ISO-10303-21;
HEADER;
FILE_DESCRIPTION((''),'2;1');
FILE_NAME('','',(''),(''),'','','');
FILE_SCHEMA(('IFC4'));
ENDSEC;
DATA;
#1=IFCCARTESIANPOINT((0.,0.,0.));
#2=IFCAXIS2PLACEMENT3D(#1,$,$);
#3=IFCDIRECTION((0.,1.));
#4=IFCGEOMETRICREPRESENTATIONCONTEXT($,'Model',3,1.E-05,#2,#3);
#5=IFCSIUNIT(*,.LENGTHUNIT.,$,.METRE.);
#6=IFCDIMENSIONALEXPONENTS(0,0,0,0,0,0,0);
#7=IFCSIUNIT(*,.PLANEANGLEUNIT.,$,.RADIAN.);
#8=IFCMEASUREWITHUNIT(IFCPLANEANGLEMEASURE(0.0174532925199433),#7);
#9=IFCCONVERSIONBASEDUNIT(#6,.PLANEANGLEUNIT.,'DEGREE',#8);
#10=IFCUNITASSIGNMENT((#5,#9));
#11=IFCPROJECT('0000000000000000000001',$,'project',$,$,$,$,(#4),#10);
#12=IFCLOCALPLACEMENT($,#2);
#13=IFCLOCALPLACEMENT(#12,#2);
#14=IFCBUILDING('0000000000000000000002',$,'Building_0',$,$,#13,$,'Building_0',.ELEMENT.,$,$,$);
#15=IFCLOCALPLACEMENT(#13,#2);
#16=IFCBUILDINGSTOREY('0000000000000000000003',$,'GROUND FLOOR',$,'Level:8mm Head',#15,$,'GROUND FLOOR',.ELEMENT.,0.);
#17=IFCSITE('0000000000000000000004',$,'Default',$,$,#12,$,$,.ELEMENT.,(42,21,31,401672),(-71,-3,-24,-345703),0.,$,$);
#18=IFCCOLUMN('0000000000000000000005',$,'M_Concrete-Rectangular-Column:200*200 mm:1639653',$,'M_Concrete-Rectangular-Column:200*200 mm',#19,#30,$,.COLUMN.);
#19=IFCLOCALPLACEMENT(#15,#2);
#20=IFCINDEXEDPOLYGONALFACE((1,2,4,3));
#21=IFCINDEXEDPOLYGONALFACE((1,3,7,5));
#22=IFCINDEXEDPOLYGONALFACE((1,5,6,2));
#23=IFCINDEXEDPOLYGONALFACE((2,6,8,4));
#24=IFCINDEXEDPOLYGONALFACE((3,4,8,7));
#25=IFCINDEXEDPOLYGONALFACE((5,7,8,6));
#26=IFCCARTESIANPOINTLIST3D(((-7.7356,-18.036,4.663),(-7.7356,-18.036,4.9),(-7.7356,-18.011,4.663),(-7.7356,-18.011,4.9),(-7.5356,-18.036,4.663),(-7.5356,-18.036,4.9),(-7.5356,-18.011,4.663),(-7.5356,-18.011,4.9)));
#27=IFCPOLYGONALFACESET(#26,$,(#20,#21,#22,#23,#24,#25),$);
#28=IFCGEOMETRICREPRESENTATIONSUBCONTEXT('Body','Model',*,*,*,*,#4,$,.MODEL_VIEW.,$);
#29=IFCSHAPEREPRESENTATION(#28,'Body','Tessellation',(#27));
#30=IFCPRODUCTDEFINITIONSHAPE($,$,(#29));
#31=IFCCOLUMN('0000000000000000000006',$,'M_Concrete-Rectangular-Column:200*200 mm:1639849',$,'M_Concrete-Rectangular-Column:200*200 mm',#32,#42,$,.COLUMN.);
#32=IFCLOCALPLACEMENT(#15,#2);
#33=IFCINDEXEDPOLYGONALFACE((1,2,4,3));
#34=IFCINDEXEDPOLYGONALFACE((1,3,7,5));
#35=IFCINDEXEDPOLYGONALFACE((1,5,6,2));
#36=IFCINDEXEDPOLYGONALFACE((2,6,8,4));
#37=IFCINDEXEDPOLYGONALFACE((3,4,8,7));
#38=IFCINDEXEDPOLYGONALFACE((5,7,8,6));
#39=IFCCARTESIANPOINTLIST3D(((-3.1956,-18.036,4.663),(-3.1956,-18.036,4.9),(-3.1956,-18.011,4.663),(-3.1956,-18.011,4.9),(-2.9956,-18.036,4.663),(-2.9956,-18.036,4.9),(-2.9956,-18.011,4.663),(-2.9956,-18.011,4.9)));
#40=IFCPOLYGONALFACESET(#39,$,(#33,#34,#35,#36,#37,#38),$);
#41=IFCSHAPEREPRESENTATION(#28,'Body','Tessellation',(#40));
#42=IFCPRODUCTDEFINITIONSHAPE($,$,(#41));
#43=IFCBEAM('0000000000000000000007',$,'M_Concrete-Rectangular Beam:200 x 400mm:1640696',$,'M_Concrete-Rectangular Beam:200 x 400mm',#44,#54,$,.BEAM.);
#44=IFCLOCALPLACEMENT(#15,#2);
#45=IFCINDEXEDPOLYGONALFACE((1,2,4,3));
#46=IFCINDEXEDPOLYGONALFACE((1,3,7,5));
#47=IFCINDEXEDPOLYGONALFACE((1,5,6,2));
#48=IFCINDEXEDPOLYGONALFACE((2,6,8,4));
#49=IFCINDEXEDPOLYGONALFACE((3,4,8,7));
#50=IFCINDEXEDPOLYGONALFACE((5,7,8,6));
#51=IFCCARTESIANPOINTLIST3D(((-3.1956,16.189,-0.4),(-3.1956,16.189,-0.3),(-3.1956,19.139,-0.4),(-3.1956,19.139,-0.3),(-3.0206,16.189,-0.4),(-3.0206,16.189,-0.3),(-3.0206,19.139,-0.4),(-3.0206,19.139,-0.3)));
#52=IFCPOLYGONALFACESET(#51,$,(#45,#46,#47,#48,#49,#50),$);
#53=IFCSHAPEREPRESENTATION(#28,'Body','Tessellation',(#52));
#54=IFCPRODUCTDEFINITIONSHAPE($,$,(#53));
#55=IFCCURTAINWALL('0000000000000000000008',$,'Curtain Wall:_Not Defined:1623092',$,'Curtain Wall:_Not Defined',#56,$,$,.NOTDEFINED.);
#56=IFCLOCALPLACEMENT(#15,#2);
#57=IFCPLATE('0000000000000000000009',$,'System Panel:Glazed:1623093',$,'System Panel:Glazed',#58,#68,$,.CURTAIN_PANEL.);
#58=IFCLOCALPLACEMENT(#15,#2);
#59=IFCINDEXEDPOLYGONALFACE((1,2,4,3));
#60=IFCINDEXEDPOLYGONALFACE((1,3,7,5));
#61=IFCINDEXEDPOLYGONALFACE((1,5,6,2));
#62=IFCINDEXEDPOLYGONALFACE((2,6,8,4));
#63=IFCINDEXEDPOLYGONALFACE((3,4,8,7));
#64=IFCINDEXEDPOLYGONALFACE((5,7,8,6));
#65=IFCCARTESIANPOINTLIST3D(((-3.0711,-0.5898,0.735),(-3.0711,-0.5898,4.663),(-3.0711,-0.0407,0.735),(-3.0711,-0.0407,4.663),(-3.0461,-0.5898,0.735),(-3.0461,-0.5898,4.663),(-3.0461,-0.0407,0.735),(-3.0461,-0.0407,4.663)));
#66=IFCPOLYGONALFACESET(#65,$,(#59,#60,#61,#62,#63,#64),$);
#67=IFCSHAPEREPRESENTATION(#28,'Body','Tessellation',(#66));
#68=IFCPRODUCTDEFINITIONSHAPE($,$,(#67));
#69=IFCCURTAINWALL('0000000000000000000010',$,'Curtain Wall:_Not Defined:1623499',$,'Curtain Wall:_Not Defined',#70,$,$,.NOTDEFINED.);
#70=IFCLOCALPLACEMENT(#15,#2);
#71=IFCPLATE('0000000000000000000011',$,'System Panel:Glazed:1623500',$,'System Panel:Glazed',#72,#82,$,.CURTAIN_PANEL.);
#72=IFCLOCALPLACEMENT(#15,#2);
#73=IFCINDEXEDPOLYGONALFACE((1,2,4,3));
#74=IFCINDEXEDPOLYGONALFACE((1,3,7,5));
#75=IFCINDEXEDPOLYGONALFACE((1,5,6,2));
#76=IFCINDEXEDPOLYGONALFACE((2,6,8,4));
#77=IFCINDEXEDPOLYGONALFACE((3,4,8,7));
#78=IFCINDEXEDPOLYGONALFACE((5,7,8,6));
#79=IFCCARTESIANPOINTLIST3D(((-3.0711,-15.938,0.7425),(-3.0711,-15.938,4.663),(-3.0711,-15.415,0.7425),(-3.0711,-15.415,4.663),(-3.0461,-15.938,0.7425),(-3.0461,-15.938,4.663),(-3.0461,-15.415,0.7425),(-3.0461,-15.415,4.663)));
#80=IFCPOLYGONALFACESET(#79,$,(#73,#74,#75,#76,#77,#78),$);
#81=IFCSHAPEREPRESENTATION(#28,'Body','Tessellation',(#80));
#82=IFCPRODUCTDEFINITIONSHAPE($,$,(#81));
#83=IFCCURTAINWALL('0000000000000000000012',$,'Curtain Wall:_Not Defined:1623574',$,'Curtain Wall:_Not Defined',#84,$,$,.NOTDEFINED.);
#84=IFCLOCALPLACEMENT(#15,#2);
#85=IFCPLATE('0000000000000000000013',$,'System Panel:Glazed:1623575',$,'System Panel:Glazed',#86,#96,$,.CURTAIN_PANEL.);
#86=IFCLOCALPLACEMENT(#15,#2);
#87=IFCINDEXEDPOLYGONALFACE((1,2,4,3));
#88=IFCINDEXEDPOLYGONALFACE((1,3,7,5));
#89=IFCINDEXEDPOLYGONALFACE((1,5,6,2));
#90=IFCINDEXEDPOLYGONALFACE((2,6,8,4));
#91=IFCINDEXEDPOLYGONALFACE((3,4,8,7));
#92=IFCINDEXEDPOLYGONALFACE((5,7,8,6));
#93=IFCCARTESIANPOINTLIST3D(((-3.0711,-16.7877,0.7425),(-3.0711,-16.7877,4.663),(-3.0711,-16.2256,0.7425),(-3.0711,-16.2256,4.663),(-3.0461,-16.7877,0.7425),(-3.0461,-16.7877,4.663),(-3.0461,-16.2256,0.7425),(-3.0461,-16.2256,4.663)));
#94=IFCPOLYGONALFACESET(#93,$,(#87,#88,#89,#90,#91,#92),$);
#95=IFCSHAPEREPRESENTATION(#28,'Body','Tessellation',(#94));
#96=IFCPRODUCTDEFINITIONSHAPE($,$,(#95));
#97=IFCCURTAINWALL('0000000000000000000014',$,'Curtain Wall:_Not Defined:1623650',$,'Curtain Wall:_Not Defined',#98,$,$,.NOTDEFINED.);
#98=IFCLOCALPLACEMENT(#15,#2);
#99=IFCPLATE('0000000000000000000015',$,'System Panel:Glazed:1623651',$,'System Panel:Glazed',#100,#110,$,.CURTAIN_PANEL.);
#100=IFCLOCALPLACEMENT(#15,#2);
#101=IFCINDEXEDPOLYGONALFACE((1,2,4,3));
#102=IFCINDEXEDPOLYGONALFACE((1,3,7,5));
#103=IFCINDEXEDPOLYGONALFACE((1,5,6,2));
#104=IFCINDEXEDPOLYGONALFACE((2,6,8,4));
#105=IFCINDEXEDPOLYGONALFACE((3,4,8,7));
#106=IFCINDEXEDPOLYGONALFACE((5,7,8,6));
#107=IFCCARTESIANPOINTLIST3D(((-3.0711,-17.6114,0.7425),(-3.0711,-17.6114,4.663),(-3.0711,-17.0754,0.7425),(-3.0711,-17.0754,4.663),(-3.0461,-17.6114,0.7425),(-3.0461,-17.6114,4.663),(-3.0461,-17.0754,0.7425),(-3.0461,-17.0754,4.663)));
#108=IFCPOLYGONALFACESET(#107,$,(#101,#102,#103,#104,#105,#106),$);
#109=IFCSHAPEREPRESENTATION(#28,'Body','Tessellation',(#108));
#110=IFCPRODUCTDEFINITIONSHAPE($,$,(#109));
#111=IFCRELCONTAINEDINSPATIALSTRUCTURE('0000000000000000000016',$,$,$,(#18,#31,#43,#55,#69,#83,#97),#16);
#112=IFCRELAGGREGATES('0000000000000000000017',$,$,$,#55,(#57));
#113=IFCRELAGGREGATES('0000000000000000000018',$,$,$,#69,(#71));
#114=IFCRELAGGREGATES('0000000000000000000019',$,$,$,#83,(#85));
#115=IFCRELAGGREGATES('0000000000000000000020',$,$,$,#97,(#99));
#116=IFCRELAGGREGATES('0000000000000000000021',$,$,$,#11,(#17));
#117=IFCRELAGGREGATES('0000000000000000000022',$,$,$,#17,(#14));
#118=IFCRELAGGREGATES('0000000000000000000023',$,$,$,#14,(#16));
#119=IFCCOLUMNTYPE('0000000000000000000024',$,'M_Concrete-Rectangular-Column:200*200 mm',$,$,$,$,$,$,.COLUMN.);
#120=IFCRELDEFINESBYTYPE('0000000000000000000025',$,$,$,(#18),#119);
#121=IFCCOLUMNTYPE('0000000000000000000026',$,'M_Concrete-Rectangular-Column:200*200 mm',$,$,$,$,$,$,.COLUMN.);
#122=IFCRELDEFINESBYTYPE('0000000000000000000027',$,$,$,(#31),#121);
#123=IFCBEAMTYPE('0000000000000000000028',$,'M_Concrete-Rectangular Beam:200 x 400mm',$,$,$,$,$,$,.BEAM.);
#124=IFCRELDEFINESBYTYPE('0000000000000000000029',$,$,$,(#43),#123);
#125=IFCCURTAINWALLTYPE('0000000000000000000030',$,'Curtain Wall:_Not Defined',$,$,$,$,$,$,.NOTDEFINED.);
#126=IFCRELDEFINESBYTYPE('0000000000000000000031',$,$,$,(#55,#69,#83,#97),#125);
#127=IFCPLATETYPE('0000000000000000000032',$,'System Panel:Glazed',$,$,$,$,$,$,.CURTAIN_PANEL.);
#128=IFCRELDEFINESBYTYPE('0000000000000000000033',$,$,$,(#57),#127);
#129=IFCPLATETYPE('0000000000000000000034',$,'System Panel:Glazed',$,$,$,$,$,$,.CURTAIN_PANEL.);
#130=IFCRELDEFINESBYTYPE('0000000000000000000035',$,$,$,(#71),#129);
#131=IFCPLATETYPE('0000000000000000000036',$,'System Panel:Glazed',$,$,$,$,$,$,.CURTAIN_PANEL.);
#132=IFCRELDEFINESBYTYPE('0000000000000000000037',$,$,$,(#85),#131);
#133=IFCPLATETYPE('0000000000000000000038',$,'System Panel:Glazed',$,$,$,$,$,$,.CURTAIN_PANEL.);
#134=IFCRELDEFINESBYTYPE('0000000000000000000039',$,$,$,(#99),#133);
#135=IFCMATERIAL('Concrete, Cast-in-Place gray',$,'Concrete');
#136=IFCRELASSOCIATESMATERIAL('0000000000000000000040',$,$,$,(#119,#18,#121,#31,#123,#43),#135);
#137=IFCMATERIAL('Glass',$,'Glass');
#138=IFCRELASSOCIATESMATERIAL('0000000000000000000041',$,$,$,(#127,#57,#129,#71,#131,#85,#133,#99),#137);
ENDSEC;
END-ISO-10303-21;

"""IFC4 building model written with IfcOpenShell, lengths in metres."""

from ifc_helpers import new_model, entity, si_unit, converted_unit, direction, frame, origin, place, context, subcontext, project, spatial, indexed_curve, outline, extrude, source, transform, mapped, material, type_object, type_shapes, element, aggregate, save


model = new_model("IFC4")

# Units and contexts
model_context = context("Model", 3, precision=1e-05, world=origin(), true_north=direction((0.0, 1.0)))
body_context = subcontext(model_context, "Body", "Model", "MODEL_VIEW")
ifc_project = project(units=[si_unit("LENGTHUNIT", "METRE"), converted_unit("PLANEANGLEUNIT", "DEGREE", entity("IfcPlaneAngleMeasure", 0.0174532925199433), si_unit("PLANEANGLEUNIT", "RADIAN"), dimensions=[0, 0, 0, 0, 0, 0, 0])], contexts=[model_context])

# Site, building, storey
site_placement = place(None, origin())
site = spatial("IfcSite", under=ifc_project, at=site_placement, Name="Default", CompositionType="ELEMENT", RefLatitude=(42, 21, 31, 401672), RefLongitude=(-71, -3, -24, -345703), RefElevation=0.0)
building_placement = place(site_placement, origin())
building = spatial("IfcBuilding", under=site, at=building_placement, Name="Building_0", LongName="Building_0", CompositionType="ELEMENT")
storey_placement = place(building_placement, origin())
storey = spatial("IfcBuildingStorey", under=building, at=storey_placement, Name="GROUND FLOOR", ObjectType="Level:8mm Head", LongName="GROUND FLOOR", CompositionType="ELEMENT", Elevation=0.0)

# Columns
ifc_material_1 = material(Name="Concrete, Cast-in-Place gray", Category="Concrete")
column_type_1 = type_object("IfcColumnType", Name="M_Concrete-Rectangular-Column:200*200 mm", PredefinedType="COLUMN", material=ifc_material_1)
shared_shape_1 = source(origin(), body_context, "Body", "SweptSolid", [
    extrude(outline(indexed_curve([(-0.0125, -0.1185), (0.0125, -0.1185), (0.0125, 0.1185), (-0.0125, 0.1185), (-0.0125, -0.1185)], self_intersect=False)), frame((-7.7356, -18.0235, 4.7815), z_axis=(1.0, 0.0, 0.0), x_axis=(0.0, -1.0, 0.0)), (0.0, 0.0, 1.0), 0.2),
])
type_shapes(column_type_1, [shared_shape_1])
column_1_placement = place(storey_placement, origin())
element("IfcColumn", 1, at=column_1_placement, inside=storey, type_object=column_type_1, material=ifc_material_1, Name="M_Concrete-Rectangular-Column:200*200 mm:1639653", ObjectType="M_Concrete-Rectangular-Column:200*200 mm", PredefinedType="COLUMN", context=body_context, shape_type="MappedRepresentation", body=[
    mapped(shared_shape_1, transform((0.0, 0.0, 0.0), scale=1.0)),
])
column_type_2 = type_object("IfcColumnType", Name="M_Concrete-Rectangular-Column:200*200 mm", PredefinedType="COLUMN", material=ifc_material_1)
shared_shape_2 = source(origin(), body_context, "Body", "SweptSolid", [
    extrude(outline(indexed_curve([(-0.0125, -0.1185), (0.0125, -0.1185), (0.0125, 0.1185), (-0.0125, 0.1185), (-0.0125, -0.1185)], self_intersect=False)), frame((-3.1956, -18.0235, 4.7815), z_axis=(1.0, 0.0, 0.0), x_axis=(0.0, -1.0, 0.0)), (0.0, 0.0, 1.0), 0.2),
])
type_shapes(column_type_2, [shared_shape_2])
column_2_placement = place(storey_placement, origin())
element("IfcColumn", 2, at=column_2_placement, inside=storey, type_object=column_type_2, material=ifc_material_1, Name="M_Concrete-Rectangular-Column:200*200 mm:1639849", ObjectType="M_Concrete-Rectangular-Column:200*200 mm", PredefinedType="COLUMN", context=body_context, shape_type="MappedRepresentation", body=[
    mapped(shared_shape_2, transform((0.0, 0.0, 0.0), scale=1.0)),
])

# Beam
beam_type = type_object("IfcBeamType", Name="M_Concrete-Rectangular Beam:200 x 400mm", PredefinedType="BEAM", material=ifc_material_1)
shared_shape_3 = source(origin(), body_context, "Body", "SweptSolid", [
    extrude(outline(indexed_curve([(-0.0875, -0.05), (0.0875, -0.05), (0.0875, 0.05), (-0.0875, 0.05), (-0.0875, -0.05)], self_intersect=False)), frame((-3.1081, 19.139, -0.35), z_axis=(0.0, -1.0, 0.0), x_axis=(-1.0, 0.0, 0.0)), (0.0, 0.0, 1.0), 2.95),
])
type_shapes(beam_type, [shared_shape_3])
beam_placement = place(storey_placement, origin())
element("IfcBeam", 3, at=beam_placement, inside=storey, type_object=beam_type, material=ifc_material_1, Name="M_Concrete-Rectangular Beam:200 x 400mm:1640696", ObjectType="M_Concrete-Rectangular Beam:200 x 400mm", PredefinedType="BEAM", context=body_context, shape_type="MappedRepresentation", body=[
    mapped(shared_shape_3, transform((0.0, 0.0, 0.0), scale=1.0)),
])

# Curtain walls, plates
curtain_wall_type = type_object("IfcCurtainWallType", Name="Curtain Wall:_Not Defined", PredefinedType="NOTDEFINED")
curtain_wall_1_placement = place(storey_placement, origin())
curtain_wall_1 = element("IfcCurtainWall", 4, at=curtain_wall_1_placement, inside=storey, type_object=curtain_wall_type, Name="Curtain Wall:_Not Defined:1623092", ObjectType="Curtain Wall:_Not Defined", PredefinedType="NOTDEFINED")
ifc_material_2 = material(Name="Glass", Category="Glass")
plate_type_1 = type_object("IfcPlateType", Name="System Panel:Glazed", PredefinedType="CURTAIN_PANEL", material=ifc_material_2)
shared_shape_4 = source(origin(), body_context, "Body", "SweptSolid", [
    extrude(outline(indexed_curve([(-0.0125, -0.2745), (0.0125, -0.2745), (0.0125, 0.2745), (-0.0125, 0.2745), (-0.0125, -0.2745)], self_intersect=False)), frame((0.0, 0.037, 0.0), z_axis=(0.0, 0.0, 1.0), x_axis=(0.0, 1.0, 0.0)), (0.0, 0.0, 1.0), 3.928),
])
type_shapes(plate_type_1, [shared_shape_4])
plate_1_placement = place(curtain_wall_1_placement, frame((-3.0956, -0.3153, 0.735), z_axis=(0.0, 0.0, 1.0), x_axis=(0.0, -1.0, 0.0)))
plate_1 = element("IfcPlate", 5, at=plate_1_placement, type_object=plate_type_1, material=ifc_material_2, Name="System Panel:Glazed:1623093", ObjectType="System Panel:Glazed", PredefinedType="CURTAIN_PANEL", context=body_context, shape_type="MappedRepresentation", body=[
    mapped(shared_shape_4, transform((0.0, 0.0, 0.0), scale=1.0)),
])
aggregate(curtain_wall_1, [plate_1])
curtain_wall_2_placement = place(storey_placement, origin())
curtain_wall_2 = element("IfcCurtainWall", 6, at=curtain_wall_2_placement, inside=storey, type_object=curtain_wall_type, Name="Curtain Wall:_Not Defined:1623499", ObjectType="Curtain Wall:_Not Defined", PredefinedType="NOTDEFINED")
plate_type_2 = type_object("IfcPlateType", Name="System Panel:Glazed", PredefinedType="CURTAIN_PANEL", material=ifc_material_2)
shared_shape_5 = source(origin(), body_context, "Body", "SweptSolid", [
    extrude(outline(indexed_curve([(-0.0125, -0.2615), (0.0125, -0.2615), (0.0125, 0.2615), (-0.0125, 0.2615), (-0.0125, -0.2615)], self_intersect=False)), frame((0.0, 0.037, 0.0), z_axis=(0.0, 0.0, 1.0), x_axis=(0.0, 1.0, 0.0)), (0.0, 0.0, 1.0), 3.9205),
])
type_shapes(plate_type_2, [shared_shape_5])
plate_2_placement = place(curtain_wall_2_placement, frame((-3.0956, -15.6765, 0.7425), z_axis=(0.0, 0.0, 1.0), x_axis=(0.0, -1.0, 0.0)))
plate_2 = element("IfcPlate", 7, at=plate_2_placement, type_object=plate_type_2, material=ifc_material_2, Name="System Panel:Glazed:1623500", ObjectType="System Panel:Glazed", PredefinedType="CURTAIN_PANEL", context=body_context, shape_type="MappedRepresentation", body=[
    mapped(shared_shape_5, transform((0.0, 0.0, 0.0), scale=1.0)),
])
aggregate(curtain_wall_2, [plate_2])
curtain_wall_3_placement = place(storey_placement, origin())
curtain_wall_3 = element("IfcCurtainWall", 8, at=curtain_wall_3_placement, inside=storey, type_object=curtain_wall_type, Name="Curtain Wall:_Not Defined:1623574", ObjectType="Curtain Wall:_Not Defined", PredefinedType="NOTDEFINED")
plate_type_3 = type_object("IfcPlateType", Name="System Panel:Glazed", PredefinedType="CURTAIN_PANEL", material=ifc_material_2)
shared_shape_6 = source(origin(), body_context, "Body", "SweptSolid", [
    extrude(outline(indexed_curve([(-0.0125, -0.2811), (0.0125, -0.2811), (0.0125, 0.2811), (-0.0125, 0.2811), (-0.0125, -0.2811)], self_intersect=False)), frame((0.0, 0.037, 0.0), z_axis=(0.0, 0.0, 1.0), x_axis=(0.0, 1.0, 0.0)), (0.0, 0.0, 1.0), 3.9205),
])
type_shapes(plate_type_3, [shared_shape_6])
plate_3_placement = place(curtain_wall_3_placement, frame((-3.0956, -16.5067, 0.7425), z_axis=(0.0, 0.0, 1.0), x_axis=(0.0, -1.0, 0.0)))
plate_3 = element("IfcPlate", 9, at=plate_3_placement, type_object=plate_type_3, material=ifc_material_2, Name="System Panel:Glazed:1623575", ObjectType="System Panel:Glazed", PredefinedType="CURTAIN_PANEL", context=body_context, shape_type="MappedRepresentation", body=[
    mapped(shared_shape_6, transform((0.0, 0.0, 0.0), scale=1.0)),
])
aggregate(curtain_wall_3, [plate_3])
curtain_wall_4_placement = place(storey_placement, origin())
curtain_wall_4 = element("IfcCurtainWall", 10, at=curtain_wall_4_placement, inside=storey, type_object=curtain_wall_type, Name="Curtain Wall:_Not Defined:1623650", ObjectType="Curtain Wall:_Not Defined", PredefinedType="NOTDEFINED")
plate_type_4 = type_object("IfcPlateType", Name="System Panel:Glazed", PredefinedType="CURTAIN_PANEL", material=ifc_material_2)
shared_shape_7 = source(origin(), body_context, "Body", "SweptSolid", [
    extrude(outline(indexed_curve([(-0.0125, -0.268), (0.0125, -0.268), (0.0125, 0.268), (-0.0125, 0.268), (-0.0125, -0.268)], self_intersect=False)), frame((0.0, 0.037, 0.0), z_axis=(0.0, 0.0, 1.0), x_axis=(0.0, 1.0, 0.0)), (0.0, 0.0, 1.0), 3.9205),
])
type_shapes(plate_type_4, [shared_shape_7])
plate_4_placement = place(curtain_wall_4_placement, frame((-3.0956, -17.3434, 0.7425), z_axis=(0.0, 0.0, 1.0), x_axis=(0.0, -1.0, 0.0)))
plate_4 = element("IfcPlate", 11, at=plate_4_placement, type_object=plate_type_4, material=ifc_material_2, Name="System Panel:Glazed:1623651", ObjectType="System Panel:Glazed", PredefinedType="CURTAIN_PANEL", context=body_context, shape_type="MappedRepresentation", body=[
    mapped(shared_shape_7, transform((0.0, 0.0, 0.0), scale=1.0)),
])
aggregate(curtain_wall_4, [plate_4])

save(model, "model.ifc")
